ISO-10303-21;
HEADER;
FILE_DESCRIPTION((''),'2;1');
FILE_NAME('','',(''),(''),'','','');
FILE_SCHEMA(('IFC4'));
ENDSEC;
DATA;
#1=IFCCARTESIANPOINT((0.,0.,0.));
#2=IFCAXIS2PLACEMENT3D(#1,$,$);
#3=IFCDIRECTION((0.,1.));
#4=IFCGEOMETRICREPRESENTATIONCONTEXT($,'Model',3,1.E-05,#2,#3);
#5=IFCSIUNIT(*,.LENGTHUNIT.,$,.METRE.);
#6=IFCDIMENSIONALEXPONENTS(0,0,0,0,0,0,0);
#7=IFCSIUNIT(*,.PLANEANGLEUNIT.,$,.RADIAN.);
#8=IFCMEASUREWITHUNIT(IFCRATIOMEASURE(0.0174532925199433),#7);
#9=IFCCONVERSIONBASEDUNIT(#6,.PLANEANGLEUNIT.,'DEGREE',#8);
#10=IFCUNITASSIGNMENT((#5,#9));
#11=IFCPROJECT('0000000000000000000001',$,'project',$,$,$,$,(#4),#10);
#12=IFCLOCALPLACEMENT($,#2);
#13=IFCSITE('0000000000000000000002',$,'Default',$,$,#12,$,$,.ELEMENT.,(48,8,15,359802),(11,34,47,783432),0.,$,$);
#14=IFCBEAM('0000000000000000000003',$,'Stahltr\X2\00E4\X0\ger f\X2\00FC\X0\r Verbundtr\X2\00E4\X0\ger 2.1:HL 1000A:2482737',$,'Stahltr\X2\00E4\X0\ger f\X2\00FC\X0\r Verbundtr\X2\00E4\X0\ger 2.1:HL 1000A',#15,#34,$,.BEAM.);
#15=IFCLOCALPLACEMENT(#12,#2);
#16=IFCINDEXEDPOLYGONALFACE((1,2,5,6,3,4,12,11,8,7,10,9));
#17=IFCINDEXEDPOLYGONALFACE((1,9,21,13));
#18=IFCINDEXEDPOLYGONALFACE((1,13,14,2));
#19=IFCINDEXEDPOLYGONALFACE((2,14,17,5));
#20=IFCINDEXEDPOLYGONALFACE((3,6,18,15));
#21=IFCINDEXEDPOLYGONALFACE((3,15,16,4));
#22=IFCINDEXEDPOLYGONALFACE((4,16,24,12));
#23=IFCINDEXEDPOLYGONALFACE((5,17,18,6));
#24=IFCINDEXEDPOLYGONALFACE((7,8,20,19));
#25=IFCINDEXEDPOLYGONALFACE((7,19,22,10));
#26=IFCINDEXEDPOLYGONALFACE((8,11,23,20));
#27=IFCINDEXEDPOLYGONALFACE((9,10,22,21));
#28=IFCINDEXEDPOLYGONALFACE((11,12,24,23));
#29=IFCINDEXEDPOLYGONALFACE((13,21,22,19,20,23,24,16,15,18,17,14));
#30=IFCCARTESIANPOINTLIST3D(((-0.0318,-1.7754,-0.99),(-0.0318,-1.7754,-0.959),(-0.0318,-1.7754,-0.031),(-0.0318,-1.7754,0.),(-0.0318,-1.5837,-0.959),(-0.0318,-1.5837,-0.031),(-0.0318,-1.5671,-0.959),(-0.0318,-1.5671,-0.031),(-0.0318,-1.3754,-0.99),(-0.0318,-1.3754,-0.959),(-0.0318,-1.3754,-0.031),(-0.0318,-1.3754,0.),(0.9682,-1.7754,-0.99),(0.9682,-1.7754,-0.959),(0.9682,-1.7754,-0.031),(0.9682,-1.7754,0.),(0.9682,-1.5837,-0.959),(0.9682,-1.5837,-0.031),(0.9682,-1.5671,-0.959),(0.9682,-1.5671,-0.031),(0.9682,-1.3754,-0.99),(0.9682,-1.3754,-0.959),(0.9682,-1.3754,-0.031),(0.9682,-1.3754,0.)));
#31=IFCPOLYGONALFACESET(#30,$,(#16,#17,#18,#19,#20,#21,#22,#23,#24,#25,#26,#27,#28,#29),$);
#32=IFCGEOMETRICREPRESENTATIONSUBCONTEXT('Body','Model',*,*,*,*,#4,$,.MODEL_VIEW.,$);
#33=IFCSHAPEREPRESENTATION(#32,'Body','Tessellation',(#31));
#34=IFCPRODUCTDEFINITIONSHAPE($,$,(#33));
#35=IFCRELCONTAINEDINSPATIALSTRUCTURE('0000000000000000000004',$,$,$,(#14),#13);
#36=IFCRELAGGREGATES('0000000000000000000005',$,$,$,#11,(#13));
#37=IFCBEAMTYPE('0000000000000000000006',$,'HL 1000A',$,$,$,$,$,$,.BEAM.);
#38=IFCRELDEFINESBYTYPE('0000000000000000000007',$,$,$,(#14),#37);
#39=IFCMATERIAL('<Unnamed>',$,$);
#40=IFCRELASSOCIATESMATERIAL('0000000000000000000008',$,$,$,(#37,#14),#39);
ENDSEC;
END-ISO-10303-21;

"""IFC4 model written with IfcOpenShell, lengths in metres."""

from ifc_helpers import new_model, entity, si_unit, converted_unit, direction, frame, frame_2d, origin, place, context, subcontext, project, spatial, polyline, segment, composite_curve, i_section, outline, extrude, source, transform, mapped, material, material_profile, profile_set, profile_usage, type_object, type_shapes, element, save


model = new_model("IFC4")

# Units and contexts
model_context = context("Model", 3, precision=1e-05, world=origin(), true_north=direction((0.0, 1.0)))
body_context = subcontext(model_context, "Body", "Model", "MODEL_VIEW")
ifc_project = project(units=[si_unit("LENGTHUNIT", "METRE"), converted_unit("PLANEANGLEUNIT", "DEGREE", entity("IfcRatioMeasure", 0.0174532925199433), si_unit("PLANEANGLEUNIT", "RADIAN"), dimensions=[0, 0, 0, 0, 0, 0, 0])], contexts=[model_context])

# Site
site_placement = place(None, origin())
site = spatial("IfcSite", under=ifc_project, at=site_placement, Name="Default", CompositionType="ELEMENT", RefLatitude=(48, 8, 15, 359802), RefLongitude=(11, 34, 47, 783432), RefElevation=0.0)

# Beam
ifc_material = material(Name="<Unnamed>")
ifc_material_profile_1 = material_profile(ifc_material, outline(composite_curve([segment(polyline([(-0.2, -0.031, 0.0), (-0.2, 0.0, 0.0)]), True, "CONTINUOUS"), segment(polyline([(-0.2, 0.0, 0.0), (0.2, 0.0, 0.0)]), True, "CONTINUOUS"), segment(polyline([(0.2, 0.0, 0.0), (0.2, -0.031, 0.0)]), True, "CONTINUOUS"), segment(polyline([(0.2, -0.031, 0.0), (0.0083, -0.031, 0.0)]), True, "CONTINUOUS"), segment(polyline([(0.0083, -0.031, 0.0), (0.0083, -0.959, 0.0)]), True, "CONTINUOUS"), segment(polyline([(0.0083, -0.959, 0.0), (0.2, -0.959, 0.0)]), True, "CONTINUOUS"), segment(polyline([(0.2, -0.959, 0.0), (0.2, -0.99, 0.0)]), True, "CONTINUOUS"), segment(polyline([(0.2, -0.99, 0.0), (-0.2, -0.99, 0.0)]), True, "CONTINUOUS"), segment(polyline([(-0.2, -0.99, 0.0), (-0.2, -0.959, 0.0)]), True, "CONTINUOUS"), segment(polyline([(-0.2, -0.959, 0.0), (-0.0083, -0.959, 0.0)]), True, "CONTINUOUS"), segment(polyline([(-0.0083, -0.959, 0.0), (-0.0083, -0.031, 0.0)]), True, "CONTINUOUS"), segment(polyline([(-0.0083, -0.031, 0.0), (-0.2, -0.031, 0.0)]), True, "CONTINUOUS")], self_intersect=False), kind="CURVE"), Name="HL 1000A")
ifc_material_profile_2 = material_profile(ifc_material, outline(composite_curve([segment(polyline([(0.5, -0.2, 0.0), (0.5, -0.2, -0.031)]), True, "CONTINUOUS"), segment(polyline([(0.5, -0.2, -0.031), (0.5, -0.0083, -0.031)]), True, "CONTINUOUS"), segment(polyline([(0.5, -0.0083, -0.031), (0.5, -0.0083, -0.959)]), True, "CONTINUOUS"), segment(polyline([(0.5, -0.0083, -0.959), (0.5, -0.2, -0.959)]), True, "CONTINUOUS"), segment(polyline([(0.5, -0.2, -0.959), (0.5, -0.2, -0.99)]), True, "CONTINUOUS"), segment(polyline([(0.5, -0.2, -0.99), (0.5, 0.2, -0.99)]), True, "CONTINUOUS"), segment(polyline([(0.5, 0.2, -0.99), (0.5, 0.2, -0.959)]), True, "CONTINUOUS"), segment(polyline([(0.5, 0.2, -0.959), (0.5, 0.0083, -0.959)]), True, "CONTINUOUS"), segment(polyline([(0.5, 0.0083, -0.959), (0.5, 0.0083, -0.031)]), True, "CONTINUOUS"), segment(polyline([(0.5, 0.0083, -0.031), (0.5, 0.2, -0.031)]), True, "CONTINUOUS"), segment(polyline([(0.5, 0.2, -0.031), (0.5, 0.2, 0.0)]), True, "CONTINUOUS"), segment(polyline([(0.5, 0.2, 0.0), (0.5, -0.2, 0.0)]), True, "CONTINUOUS")], self_intersect=False), kind="CURVE"), Name="HL 1000A")
ifc_profile_set = profile_set([ifc_material_profile_1, ifc_material_profile_2], Name="HL 1000A")
ifc_profile_usage = profile_usage(ifc_profile_set, cardinal=8)
beam_type = type_object("IfcBeamType", Name="HL 1000A", PredefinedType="BEAM", material=ifc_profile_set)
shared_shape = source(origin(), body_context, "Body", "SweptSolid", [
    extrude(i_section(OverallWidth=0.4, OverallDepth=0.99, WebThickness=0.0166, FlangeThickness=0.031, at=frame_2d((0.0, 0.0), x_axis=(0.0, 1.0))), frame((-0.5, 0.0, -0.495), z_axis=(1.0, 0.0, 0.0), x_axis=(0.0, 0.0, -1.0)), (0.0, 0.0, 1.0), 1.0),
])
type_shapes(beam_type, [shared_shape])
beam_placement = place(site_placement, frame((0.4682, -1.5754, 0.0)))
element("IfcBeam", 1, at=beam_placement, inside=site, type_object=beam_type, material=ifc_profile_usage, Name="Stahlträger für Verbundträger 2.1:HL 1000A:2482737", ObjectType="Stahlträger für Verbundträger 2.1:HL 1000A", PredefinedType="BEAM", context=body_context, shape_type="MappedRepresentation", body=[
    mapped(shared_shape, transform((0.0, 0.0, 0.0), scale=1.0)),
])

save(model, "model.ifc")
